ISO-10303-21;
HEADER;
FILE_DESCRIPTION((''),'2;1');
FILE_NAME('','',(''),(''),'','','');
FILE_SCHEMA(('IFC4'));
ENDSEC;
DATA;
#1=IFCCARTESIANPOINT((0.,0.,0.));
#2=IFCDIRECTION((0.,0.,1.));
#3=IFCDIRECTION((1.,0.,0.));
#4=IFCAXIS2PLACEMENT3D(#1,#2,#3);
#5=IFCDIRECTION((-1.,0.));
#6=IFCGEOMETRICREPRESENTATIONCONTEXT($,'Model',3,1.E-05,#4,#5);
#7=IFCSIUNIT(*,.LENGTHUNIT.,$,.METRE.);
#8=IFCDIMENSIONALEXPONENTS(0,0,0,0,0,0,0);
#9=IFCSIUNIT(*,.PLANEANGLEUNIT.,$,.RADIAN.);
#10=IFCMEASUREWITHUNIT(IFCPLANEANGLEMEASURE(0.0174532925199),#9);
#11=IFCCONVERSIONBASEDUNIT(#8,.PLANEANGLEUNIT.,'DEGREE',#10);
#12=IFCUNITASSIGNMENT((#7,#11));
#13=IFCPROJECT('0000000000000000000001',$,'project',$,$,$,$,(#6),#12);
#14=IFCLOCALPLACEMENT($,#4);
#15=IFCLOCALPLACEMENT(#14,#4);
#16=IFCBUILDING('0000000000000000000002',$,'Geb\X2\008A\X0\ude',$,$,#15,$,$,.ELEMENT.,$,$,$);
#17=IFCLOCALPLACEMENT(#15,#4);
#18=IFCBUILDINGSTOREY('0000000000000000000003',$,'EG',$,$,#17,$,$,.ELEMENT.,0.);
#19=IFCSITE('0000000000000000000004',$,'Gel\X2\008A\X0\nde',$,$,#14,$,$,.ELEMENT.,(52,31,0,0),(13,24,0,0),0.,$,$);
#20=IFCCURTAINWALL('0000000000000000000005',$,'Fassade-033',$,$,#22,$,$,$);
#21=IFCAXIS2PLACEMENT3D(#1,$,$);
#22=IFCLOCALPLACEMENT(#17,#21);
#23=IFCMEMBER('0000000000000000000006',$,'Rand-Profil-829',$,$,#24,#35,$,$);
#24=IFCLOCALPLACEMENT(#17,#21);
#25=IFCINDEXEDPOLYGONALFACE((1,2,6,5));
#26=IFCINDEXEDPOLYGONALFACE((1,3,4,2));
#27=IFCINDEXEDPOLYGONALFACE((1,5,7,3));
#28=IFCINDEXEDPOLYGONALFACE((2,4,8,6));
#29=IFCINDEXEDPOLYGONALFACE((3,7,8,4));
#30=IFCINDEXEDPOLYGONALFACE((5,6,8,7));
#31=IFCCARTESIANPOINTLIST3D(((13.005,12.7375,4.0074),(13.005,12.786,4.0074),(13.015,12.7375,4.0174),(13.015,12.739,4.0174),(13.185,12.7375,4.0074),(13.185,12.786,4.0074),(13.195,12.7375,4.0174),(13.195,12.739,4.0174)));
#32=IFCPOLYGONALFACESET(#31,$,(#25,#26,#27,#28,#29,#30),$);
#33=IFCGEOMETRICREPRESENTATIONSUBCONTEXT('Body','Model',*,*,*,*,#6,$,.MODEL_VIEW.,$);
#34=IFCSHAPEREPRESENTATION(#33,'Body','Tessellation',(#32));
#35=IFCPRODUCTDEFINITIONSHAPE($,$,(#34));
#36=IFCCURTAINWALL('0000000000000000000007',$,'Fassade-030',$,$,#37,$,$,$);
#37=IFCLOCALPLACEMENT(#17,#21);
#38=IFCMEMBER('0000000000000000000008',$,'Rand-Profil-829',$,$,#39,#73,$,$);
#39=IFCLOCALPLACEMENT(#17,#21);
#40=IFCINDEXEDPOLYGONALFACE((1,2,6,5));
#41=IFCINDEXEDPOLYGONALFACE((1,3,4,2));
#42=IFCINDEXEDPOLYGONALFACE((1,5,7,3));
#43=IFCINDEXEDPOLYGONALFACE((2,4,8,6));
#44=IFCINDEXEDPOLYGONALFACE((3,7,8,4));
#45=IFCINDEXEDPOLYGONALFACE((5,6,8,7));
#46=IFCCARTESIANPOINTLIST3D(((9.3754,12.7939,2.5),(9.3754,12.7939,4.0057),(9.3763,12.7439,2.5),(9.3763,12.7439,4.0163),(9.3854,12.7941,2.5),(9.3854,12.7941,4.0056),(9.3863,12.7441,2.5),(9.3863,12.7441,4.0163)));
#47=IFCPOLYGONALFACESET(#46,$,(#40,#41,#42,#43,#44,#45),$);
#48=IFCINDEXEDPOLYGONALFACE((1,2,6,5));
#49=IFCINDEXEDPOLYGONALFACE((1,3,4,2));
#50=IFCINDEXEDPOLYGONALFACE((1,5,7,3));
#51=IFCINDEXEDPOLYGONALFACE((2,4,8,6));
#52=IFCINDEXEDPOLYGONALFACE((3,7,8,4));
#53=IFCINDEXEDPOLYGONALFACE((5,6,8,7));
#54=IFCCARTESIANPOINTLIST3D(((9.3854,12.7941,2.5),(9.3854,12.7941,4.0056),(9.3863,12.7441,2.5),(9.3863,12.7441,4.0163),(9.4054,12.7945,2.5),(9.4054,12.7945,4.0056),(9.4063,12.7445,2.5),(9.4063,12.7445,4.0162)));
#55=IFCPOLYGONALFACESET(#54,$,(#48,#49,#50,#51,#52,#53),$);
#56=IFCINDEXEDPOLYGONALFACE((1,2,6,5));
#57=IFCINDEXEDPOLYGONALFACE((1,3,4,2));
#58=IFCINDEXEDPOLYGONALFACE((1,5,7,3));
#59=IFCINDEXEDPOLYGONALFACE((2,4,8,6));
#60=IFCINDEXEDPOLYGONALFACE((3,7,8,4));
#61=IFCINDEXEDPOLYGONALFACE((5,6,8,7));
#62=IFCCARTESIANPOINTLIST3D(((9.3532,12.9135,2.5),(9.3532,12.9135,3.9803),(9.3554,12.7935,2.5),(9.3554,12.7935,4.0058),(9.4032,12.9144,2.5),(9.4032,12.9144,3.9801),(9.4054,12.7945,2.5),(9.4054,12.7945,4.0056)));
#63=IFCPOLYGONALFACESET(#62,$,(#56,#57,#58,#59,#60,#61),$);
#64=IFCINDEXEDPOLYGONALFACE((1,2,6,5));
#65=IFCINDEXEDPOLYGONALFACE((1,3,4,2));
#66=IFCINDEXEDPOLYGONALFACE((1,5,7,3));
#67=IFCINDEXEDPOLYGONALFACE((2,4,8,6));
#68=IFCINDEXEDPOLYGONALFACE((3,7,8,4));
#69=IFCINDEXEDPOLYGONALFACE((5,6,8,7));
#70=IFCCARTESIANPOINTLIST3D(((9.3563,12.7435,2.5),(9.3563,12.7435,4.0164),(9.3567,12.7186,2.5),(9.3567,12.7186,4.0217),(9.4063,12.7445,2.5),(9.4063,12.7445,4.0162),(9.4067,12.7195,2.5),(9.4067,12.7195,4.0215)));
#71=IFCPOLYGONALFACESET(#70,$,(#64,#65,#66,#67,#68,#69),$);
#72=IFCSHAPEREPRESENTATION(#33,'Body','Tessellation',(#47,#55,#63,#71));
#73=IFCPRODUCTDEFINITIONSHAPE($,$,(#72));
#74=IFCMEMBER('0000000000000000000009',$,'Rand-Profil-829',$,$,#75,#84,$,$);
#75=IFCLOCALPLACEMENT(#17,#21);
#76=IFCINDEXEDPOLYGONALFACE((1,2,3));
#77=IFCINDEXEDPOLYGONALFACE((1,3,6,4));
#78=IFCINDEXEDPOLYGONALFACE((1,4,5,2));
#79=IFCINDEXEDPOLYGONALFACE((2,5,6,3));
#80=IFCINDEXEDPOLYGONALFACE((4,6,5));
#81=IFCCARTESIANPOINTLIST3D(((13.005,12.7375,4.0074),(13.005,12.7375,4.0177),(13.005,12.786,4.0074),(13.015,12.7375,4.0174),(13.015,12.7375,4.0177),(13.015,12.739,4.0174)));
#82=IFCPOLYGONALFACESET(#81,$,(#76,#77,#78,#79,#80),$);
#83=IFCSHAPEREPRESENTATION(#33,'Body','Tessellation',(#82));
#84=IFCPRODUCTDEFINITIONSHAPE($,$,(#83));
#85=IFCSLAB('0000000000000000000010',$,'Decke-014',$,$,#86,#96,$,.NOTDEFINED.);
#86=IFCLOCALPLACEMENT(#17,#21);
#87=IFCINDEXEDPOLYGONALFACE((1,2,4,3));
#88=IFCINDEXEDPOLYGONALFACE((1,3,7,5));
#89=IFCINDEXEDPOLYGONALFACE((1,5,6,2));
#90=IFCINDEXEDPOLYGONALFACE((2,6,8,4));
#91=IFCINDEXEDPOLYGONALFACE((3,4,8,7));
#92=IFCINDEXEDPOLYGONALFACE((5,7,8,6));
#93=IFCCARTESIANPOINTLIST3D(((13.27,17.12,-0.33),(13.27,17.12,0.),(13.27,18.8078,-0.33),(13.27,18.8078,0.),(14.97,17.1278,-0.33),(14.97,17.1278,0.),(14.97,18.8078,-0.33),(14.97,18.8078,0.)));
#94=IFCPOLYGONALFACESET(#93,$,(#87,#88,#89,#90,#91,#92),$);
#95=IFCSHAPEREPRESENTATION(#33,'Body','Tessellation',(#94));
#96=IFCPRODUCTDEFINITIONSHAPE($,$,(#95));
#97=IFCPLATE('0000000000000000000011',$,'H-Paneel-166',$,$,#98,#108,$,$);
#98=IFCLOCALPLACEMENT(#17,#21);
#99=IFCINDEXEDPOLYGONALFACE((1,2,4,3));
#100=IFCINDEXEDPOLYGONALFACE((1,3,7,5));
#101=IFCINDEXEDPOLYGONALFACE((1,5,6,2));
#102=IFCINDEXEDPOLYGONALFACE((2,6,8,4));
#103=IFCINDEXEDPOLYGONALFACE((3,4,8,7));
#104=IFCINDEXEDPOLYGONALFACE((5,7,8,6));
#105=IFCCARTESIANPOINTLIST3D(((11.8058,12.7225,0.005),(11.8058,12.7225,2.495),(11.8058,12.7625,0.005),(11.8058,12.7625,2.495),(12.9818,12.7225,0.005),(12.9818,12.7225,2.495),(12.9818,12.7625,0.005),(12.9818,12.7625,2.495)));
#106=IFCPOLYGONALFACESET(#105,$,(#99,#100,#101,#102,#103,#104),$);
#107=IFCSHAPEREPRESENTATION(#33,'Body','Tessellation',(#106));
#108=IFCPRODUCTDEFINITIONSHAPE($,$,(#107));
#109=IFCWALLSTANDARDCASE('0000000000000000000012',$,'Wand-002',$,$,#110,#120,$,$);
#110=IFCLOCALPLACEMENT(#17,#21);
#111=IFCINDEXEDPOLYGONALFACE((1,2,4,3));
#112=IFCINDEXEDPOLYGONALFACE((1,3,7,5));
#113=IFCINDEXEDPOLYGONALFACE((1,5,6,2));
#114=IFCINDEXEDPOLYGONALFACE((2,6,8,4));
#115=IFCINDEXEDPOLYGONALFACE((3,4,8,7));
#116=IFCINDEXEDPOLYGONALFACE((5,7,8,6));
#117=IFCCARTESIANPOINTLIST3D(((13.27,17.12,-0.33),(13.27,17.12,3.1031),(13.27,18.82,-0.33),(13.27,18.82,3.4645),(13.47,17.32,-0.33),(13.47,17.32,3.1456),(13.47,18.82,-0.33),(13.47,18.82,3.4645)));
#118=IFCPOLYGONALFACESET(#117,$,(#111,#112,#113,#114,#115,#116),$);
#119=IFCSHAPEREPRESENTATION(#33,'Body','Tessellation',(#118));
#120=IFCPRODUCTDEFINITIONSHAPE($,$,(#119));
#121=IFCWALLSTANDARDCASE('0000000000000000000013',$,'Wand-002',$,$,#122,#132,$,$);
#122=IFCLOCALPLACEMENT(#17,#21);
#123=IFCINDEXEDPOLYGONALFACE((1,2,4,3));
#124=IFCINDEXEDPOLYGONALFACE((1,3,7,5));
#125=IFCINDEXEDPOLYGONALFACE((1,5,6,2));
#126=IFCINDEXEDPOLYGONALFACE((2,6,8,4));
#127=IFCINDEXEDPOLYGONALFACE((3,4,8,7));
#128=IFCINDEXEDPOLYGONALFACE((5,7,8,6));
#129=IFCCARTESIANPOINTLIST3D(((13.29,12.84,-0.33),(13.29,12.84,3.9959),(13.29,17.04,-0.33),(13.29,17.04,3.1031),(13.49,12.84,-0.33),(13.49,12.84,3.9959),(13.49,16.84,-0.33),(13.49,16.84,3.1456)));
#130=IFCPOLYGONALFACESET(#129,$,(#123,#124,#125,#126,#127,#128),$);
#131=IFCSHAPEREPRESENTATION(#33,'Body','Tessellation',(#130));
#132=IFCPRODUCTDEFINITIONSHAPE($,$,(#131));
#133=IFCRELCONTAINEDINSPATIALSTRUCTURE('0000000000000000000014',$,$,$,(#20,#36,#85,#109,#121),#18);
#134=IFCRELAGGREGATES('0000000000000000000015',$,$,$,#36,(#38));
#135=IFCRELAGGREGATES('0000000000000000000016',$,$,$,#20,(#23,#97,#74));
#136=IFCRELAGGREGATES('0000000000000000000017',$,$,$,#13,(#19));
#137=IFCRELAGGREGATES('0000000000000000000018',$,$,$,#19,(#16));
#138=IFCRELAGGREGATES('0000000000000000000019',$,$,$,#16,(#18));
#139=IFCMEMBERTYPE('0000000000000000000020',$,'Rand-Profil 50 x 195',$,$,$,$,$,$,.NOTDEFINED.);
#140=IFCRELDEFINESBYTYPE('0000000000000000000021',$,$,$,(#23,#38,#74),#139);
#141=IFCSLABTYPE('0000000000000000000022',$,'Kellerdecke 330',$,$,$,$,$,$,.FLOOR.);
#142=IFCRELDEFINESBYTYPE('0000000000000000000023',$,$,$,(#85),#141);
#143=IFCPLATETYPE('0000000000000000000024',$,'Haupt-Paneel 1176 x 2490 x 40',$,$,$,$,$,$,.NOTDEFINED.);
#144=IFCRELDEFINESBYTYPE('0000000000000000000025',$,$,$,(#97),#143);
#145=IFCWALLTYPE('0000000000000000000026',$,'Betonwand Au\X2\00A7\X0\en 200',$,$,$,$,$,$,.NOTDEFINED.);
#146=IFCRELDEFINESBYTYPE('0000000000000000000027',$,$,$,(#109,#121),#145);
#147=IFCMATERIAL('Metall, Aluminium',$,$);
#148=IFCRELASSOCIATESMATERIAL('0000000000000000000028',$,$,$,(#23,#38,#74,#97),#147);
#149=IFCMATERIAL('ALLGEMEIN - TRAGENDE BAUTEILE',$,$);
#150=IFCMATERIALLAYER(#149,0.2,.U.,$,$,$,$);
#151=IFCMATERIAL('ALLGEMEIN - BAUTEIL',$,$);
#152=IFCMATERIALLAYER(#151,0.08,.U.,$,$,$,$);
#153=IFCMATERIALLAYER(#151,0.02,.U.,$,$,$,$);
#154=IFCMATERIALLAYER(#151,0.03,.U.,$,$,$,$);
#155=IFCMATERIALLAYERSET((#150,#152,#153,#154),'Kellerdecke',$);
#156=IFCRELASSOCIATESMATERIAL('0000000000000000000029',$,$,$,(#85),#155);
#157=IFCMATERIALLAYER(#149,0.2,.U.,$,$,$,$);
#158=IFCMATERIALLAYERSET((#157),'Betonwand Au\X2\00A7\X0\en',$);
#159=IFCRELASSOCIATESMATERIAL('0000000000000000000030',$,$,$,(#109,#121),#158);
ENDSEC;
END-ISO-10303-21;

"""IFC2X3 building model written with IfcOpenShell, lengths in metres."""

from ifc_helpers import new_model, entity, si_unit, converted_unit, direction, frame, origin_with_axes, place, context, subcontext, project, spatial, polyline, outline, extrude, clip, halfspace, material, layer, layer_set, layer_usage, type_object, element, aggregate, save


model = new_model("IFC2X3")

# Units and contexts
model_context = context("Model", 3, precision=1e-05, world=origin_with_axes(), true_north=direction((-1.0, 0.0)))
body_context = subcontext(model_context, "Body", "Model", "MODEL_VIEW")
ifc_project = project(units=[si_unit("LENGTHUNIT", "METRE"), converted_unit("PLANEANGLEUNIT", "DEGREE", entity("IfcPlaneAngleMeasure", 0.0174532925199), si_unit("PLANEANGLEUNIT", "RADIAN"), dimensions=[0, 0, 0, 0, 0, 0, 0])], contexts=[model_context])

# Site, building, storey
site_placement = place(None, origin_with_axes())
site = spatial("IfcSite", under=ifc_project, at=site_placement, Name="Gel\u008ande", CompositionType="ELEMENT", RefLatitude=(52, 31, 0, 0), RefLongitude=(13, 24, 0, 0), RefElevation=0.0)
building_placement = place(site_placement, origin_with_axes())
building = spatial("IfcBuilding", under=site, at=building_placement, Name="Geb\u008aude", CompositionType="ELEMENT")
storey_placement = place(building_placement, origin_with_axes())
storey = spatial("IfcBuildingStorey", under=building, at=storey_placement, Name="EG", CompositionType="ELEMENT", Elevation=0.0)

# Curtain wall, member
curtain_wall_1_placement = place(storey_placement, frame((12.3938, 12.7625, 0.0), z_axis=(0.0, 0.0, 1.0), x_axis=(1.0, 0.0, 0.0)))
curtain_wall_1 = element("IfcCurtainWall", 1, at=curtain_wall_1_placement, inside=storey, Name="Fassade-033")
ifc_material_1 = material(Name="Metall, Aluminium")
member_type_1 = type_object("IfcMemberType", Name="Rand-Profil 50 x 195", PredefinedType="NOTDEFINED")
member_1_placement = place(curtain_wall_1_placement, frame((0.7962, 0.0, 4.0124), z_axis=(-1.0, 0.0, 0.0), x_axis=(0.0, 0.0, -1.0)))
member_1 = element("IfcMember", 2, at=member_1_placement, type_object=member_type_1, material=ifc_material_1, Name="Rand-Profil-829", context=body_context, shape_type="Clipping", body=[
    clip(clip(extrude(outline(polyline([(-0.0235, -0.005), (0.0235, 0.005), (-0.025, 0.005), (-0.025, -0.005), (-0.0235, -0.005)])), frame((0.0, 0.0, -0.005), z_axis=(0.0, 0.0, 1.0), x_axis=(0.0, -1.0, 0.0)), (0.0, 0.0, 1.0), 0.19), halfspace(frame((0.0, 0.0, 0.0), z_axis=(-0.707107, 0.0, 0.707107), x_axis=(-0.707107, 0.0, -0.707107)), True)), halfspace(frame((-0.09, 0.0, 0.09), z_axis=(0.707107, 0.0, -0.707107), x_axis=(0.707107, 0.0, 0.707107)), True)),
])

# Curtain wall, member
curtain_wall_2_placement = place(storey_placement, frame((8.7714, 12.7579, 0.0), z_axis=(0.0, 0.0, 1.0), x_axis=(1.0, 0.0, 0.0)))
curtain_wall_2 = element("IfcCurtainWall", 3, at=curtain_wall_2_placement, inside=storey, Name="Fassade-030")
member_2_placement = place(curtain_wall_2_placement, frame((0.6094, 0.0111, 2.5), z_axis=(0.0, 0.0, 1.0), x_axis=(-0.999835, -0.018178, 0.0)))
member_2 = element("IfcMember", 4, at=member_2_placement, type_object=member_type_1, material=ifc_material_1, Name="Rand-Profil-829", context=body_context, shape_type="Clipping", body=[
    clip(extrude(outline(polyline([(0.0055, -0.0249), (0.0045, 0.0251), (-0.0055, 0.0249), (-0.0045, -0.0251), (0.0055, -0.0249)])), frame((0.0, 0.0, 0.0), z_axis=(0.0, 0.0, 1.0), x_axis=(-0.999835, 0.018178, 0.0)), (0.0, 0.0, 1.0), 1.5163), halfspace(frame((-0.0056, -0.3072, 1.4457), z_axis=(0.003779, 0.207877, -0.978148), x_axis=(0.0, -0.978155, -0.207879)), True)),
    clip(extrude(outline(polyline([(0.0255, -0.0245), (0.0245, 0.0255), (0.0045, 0.0251), (0.0055, -0.0249), (0.0255, -0.0245)])), frame((0.0, 0.0, 0.0), z_axis=(0.0, 0.0, 1.0), x_axis=(-0.999835, 0.018178, 0.0)), (0.0, 0.0, 1.0), 1.5163), halfspace(frame((-0.0056, -0.3072, 1.4457), z_axis=(0.003779, 0.207877, -0.978148), x_axis=(0.0, -0.978155, -0.207879)), True)),
    clip(extrude(outline(polyline([(0.0245, 0.0255), (0.0224, 0.1454), (-0.0276, 0.1445), (-0.0255, 0.0245), (0.0245, 0.0255)])), frame((0.0, 0.0, 0.0), z_axis=(0.0, 0.0, 1.0), x_axis=(-0.999835, 0.018178, 0.0)), (0.0, 0.0, 1.0), 1.5058), halfspace(frame((-0.0056, -0.3072, 1.4457), z_axis=(0.003779, 0.207877, -0.978148), x_axis=(0.0, -0.978155, -0.207879)), True)),
    clip(extrude(outline(polyline([(0.0259, -0.0495), (0.0255, -0.0245), (-0.0245, -0.0255), (-0.0241, -0.0504), (0.0259, -0.0495)])), frame((0.0, 0.0, 0.0), z_axis=(0.0, 0.0, 1.0), x_axis=(-0.999835, 0.018178, 0.0)), (0.0, 0.0, 1.0), 1.5217), halfspace(frame((-0.0056, -0.3072, 1.4457), z_axis=(0.003779, 0.207877, -0.978148), x_axis=(0.0, -0.978155, -0.207879)), True)),
])
aggregate(curtain_wall_2, [member_2])

# Member
member_3_placement = place(curtain_wall_1_placement, frame((0.6162, 0.0, 4.0124), z_axis=(0.0, 0.0, 1.0), x_axis=(-1.0, 0.0, 0.0)))
member_3 = element("IfcMember", 5, at=member_3_placement, type_object=member_type_1, material=ifc_material_1, Name="Rand-Profil-829", context=body_context, shape_type="Clipping", body=[
    clip(clip(extrude(outline(polyline([(0.005, -0.0235), (-0.005, 0.0235), (-0.005, -0.025), (0.005, -0.025), (0.005, -0.0235)])), frame((0.0, 0.0, -0.005), z_axis=(0.0, 0.0, 1.0), x_axis=(-1.0, 0.0, 0.0)), (0.0, 0.0, 1.0), 0.0103), halfspace(frame((0.0, 0.0, 0.0), z_axis=(0.707107, 0.0, 0.707107), x_axis=(-0.707107, 0.0, 0.707107)), True)), halfspace(frame((0.0, 0.0, 0.0), z_axis=(0.0, 0.207912, -0.978148), x_axis=(0.0, -0.978148, -0.207912)), True)),
])

# Slab
ifc_material_2 = material(Name="ALLGEMEIN - TRAGENDE BAUTEILE")
ifc_layer_1 = layer(ifc_material_2, 0.2, ventilated="UNKNOWN")
ifc_material_3 = material(Name="ALLGEMEIN - BAUTEIL")
ifc_layer_2 = layer(ifc_material_3, 0.08, ventilated="UNKNOWN")
ifc_layer_3 = layer(ifc_material_3, 0.02, ventilated="UNKNOWN")
ifc_layer_4 = layer(ifc_material_3, 0.03, ventilated="UNKNOWN")
ifc_layer_set_1 = layer_set([ifc_layer_1, ifc_layer_2, ifc_layer_3, ifc_layer_4], Name="Kellerdecke")
ifc_layer_usage_1 = layer_usage(ifc_layer_set_1, "AXIS3", "NEGATIVE", 0.33)
slab_type = type_object("IfcSlabType", Name="Kellerdecke 330", PredefinedType="FLOOR")
slab_placement = place(storey_placement, frame((13.27, 18.8078, 0.0), z_axis=(0.0, 0.0, 1.0), x_axis=(1.0, 0.0, 0.0)))
element("IfcSlab", 6, at=slab_placement, inside=storey, type_object=slab_type, material=ifc_layer_usage_1, Name="Decke-014", PredefinedType="NOTDEFINED", context=body_context, shape_type="SweptSolid", body=[
    extrude(outline(polyline([(0.0, 0.0), (0.0, -1.6878), (1.7, -1.68), (1.7, 0.0), (0.0, 0.0)])), frame((0.0, 0.0, -0.33), z_axis=(0.0, 0.0, 1.0), x_axis=(1.0, 0.0, 0.0)), (0.0, 0.0, 1.0), 0.33),
])

# Plate
plate_type_1 = type_object("IfcPlateType", Name="Haupt-Paneel 1176 x 2490 x 40", PredefinedType="NOTDEFINED")
plate_1_placement = place(curtain_wall_1_placement, frame((0.0, 0.0, 1.25), z_axis=(0.0, 0.0, 1.0), x_axis=(-1.0, 0.0, 0.0)))
plate_1 = element("IfcPlate", 7, at=plate_1_placement, type_object=plate_type_1, material=ifc_material_1, Name="H-Paneel-166", context=body_context, shape_type="SweptSolid", body=[
    extrude(outline(polyline([(0.005, 0.005), (1.181, 0.005), (1.181, 2.495), (0.005, 2.495), (0.005, 0.005)])), frame((0.593, 0.0, -1.25), z_axis=(0.0, 1.0, 0.0), x_axis=(-1.0, 0.0, 0.0)), (0.0, 0.0, 1.0), 0.04),
])
aggregate(curtain_wall_1, [member_1, plate_1, member_3])

# Walls
ifc_layer_5 = layer(ifc_material_2, 0.2, ventilated="UNKNOWN")
ifc_layer_set_2 = layer_set([ifc_layer_5], Name="Betonwand Au§en")
wall_type_1 = type_object("IfcWallType", Name="Betonwand Au§en 200", PredefinedType="NOTDEFINED")
ifc_layer_usage_2 = layer_usage(ifc_layer_set_2, "AXIS2", "NEGATIVE", 0.0)
wall_1_placement = place(storey_placement, frame((13.47, 18.82, -0.33), z_axis=(0.0, 0.0, 1.0), x_axis=(0.0, -1.0, 0.0)))
element("IfcWallStandardCase", 8, at=wall_1_placement, inside=storey, type_object=wall_type_1, material=ifc_layer_usage_2, Name="Wand-002", context=body_context, shape_type="Clipping", body=[
    clip(extrude(outline(polyline([(0.0, -0.2), (1.7, -0.2), (1.5, 0.0), (0.0, 0.0), (0.0, -0.2)])), origin_with_axes(), (0.0, 0.0, 1.0), 6.0), halfspace(frame((0.7717, 0.0, 3.6305), z_axis=(-0.207912, 0.0, -0.978148), x_axis=(0.978148, 0.0, -0.207912)), True)),
])
ifc_layer_usage_3 = layer_usage(ifc_layer_set_2, "AXIS2", "POSITIVE", 0.0)
wall_2_placement = place(storey_placement, frame((13.49, 12.84, -0.33), z_axis=(0.0, 0.0, 1.0), x_axis=(0.0, 1.0, 0.0)))
element("IfcWallStandardCase", 9, at=wall_2_placement, inside=storey, type_object=wall_type_1, material=ifc_layer_usage_3, Name="Wand-002", context=body_context, shape_type="Clipping", body=[
    clip(extrude(outline(polyline([(0.0, 0.0), (4.0, 0.0), (4.2, 0.2), (0.0, 0.2), (0.0, 0.0)])), origin_with_axes(), (0.0, 0.0, 1.0), 6.0), halfspace(frame((0.8797, 0.0, 4.1389), z_axis=(-0.207912, 0.0, -0.978148), x_axis=(0.978148, 0.0, -0.207912)), True)),
])

save(model, "model.ifc")
